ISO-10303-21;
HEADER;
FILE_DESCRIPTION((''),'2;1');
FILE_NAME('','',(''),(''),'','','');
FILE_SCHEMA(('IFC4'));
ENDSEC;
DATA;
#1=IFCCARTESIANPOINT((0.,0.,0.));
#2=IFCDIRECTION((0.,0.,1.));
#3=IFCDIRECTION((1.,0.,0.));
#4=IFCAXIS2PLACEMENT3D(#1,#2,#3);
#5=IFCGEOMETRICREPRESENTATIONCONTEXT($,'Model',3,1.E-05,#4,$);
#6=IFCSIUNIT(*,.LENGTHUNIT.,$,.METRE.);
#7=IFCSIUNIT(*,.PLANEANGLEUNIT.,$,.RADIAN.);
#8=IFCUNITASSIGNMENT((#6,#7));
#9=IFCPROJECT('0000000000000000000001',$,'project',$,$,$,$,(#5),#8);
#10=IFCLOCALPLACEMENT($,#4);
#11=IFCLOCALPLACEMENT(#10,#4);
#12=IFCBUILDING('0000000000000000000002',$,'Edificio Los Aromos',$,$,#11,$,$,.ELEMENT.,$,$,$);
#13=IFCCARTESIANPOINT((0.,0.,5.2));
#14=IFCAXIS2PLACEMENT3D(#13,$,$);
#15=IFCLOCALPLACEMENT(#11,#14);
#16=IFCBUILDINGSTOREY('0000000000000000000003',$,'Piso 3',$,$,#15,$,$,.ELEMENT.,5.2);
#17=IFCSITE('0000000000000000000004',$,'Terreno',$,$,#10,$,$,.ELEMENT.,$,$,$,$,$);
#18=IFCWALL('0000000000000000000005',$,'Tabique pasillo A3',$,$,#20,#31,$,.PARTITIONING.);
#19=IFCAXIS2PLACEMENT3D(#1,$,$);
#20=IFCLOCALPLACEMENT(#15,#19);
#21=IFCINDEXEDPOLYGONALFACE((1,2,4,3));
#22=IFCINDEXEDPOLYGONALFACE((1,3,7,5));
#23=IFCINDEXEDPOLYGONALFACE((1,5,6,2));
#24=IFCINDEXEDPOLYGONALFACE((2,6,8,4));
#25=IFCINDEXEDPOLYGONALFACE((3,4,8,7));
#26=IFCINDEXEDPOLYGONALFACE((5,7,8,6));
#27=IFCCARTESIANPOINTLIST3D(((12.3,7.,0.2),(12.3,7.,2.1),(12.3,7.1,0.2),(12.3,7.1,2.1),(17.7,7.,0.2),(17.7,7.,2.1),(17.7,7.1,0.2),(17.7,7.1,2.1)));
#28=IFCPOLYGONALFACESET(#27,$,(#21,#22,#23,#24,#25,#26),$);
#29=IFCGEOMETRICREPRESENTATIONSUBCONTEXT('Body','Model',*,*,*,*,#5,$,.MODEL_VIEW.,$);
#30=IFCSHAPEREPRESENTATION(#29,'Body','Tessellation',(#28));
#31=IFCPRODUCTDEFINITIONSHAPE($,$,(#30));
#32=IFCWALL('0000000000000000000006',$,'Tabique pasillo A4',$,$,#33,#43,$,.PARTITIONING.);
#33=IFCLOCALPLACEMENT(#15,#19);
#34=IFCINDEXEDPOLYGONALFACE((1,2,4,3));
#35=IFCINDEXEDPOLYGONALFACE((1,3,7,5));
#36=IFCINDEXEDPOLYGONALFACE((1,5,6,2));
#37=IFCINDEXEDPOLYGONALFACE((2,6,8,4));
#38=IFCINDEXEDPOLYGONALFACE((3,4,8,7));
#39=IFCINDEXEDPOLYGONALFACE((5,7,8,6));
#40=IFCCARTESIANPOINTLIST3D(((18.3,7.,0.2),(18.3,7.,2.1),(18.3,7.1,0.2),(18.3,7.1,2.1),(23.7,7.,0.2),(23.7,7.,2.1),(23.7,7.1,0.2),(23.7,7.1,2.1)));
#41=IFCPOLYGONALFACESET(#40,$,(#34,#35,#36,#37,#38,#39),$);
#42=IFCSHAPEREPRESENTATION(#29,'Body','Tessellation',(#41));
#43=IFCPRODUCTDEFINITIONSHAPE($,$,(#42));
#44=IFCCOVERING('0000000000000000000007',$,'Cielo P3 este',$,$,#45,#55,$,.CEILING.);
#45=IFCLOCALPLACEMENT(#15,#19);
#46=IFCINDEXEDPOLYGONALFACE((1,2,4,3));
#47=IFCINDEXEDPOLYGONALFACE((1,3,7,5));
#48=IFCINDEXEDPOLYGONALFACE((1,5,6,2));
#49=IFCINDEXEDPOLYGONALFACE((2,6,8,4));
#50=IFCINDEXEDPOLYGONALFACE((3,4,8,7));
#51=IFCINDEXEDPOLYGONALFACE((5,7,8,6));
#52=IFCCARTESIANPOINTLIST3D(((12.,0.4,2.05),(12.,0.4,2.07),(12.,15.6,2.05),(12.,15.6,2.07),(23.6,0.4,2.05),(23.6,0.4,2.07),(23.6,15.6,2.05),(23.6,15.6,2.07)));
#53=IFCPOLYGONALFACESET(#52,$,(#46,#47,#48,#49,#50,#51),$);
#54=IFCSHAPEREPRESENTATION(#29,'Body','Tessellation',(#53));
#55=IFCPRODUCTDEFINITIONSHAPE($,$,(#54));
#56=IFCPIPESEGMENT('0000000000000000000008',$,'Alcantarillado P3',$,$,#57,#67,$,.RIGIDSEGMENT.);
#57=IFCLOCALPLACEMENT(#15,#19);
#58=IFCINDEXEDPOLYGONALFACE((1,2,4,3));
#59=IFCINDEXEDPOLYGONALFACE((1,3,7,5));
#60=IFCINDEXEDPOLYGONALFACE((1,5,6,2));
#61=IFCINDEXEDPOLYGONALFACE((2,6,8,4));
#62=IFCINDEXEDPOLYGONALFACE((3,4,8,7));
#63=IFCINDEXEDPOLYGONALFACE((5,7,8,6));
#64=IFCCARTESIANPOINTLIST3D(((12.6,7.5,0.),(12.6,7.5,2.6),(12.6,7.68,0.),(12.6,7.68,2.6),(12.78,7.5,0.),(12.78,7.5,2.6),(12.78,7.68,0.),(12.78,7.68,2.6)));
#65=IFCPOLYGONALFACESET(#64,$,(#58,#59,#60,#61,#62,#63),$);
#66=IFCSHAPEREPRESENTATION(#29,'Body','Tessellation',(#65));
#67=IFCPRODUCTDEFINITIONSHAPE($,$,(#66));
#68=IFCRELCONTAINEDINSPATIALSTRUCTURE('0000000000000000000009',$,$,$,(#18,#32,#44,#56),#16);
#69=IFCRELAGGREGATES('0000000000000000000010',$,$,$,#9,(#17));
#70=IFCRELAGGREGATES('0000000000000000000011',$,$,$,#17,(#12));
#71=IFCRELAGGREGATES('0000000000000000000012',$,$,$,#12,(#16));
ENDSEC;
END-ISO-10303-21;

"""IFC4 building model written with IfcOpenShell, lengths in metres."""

from ifc_helpers import new_model, si_unit, frame, frame_2d, origin_with_axes, place, context, subcontext, project, spatial, rectangle, extrude, element, save


model = new_model("IFC4")

# Units and contexts
model_context = context("Model", 3, precision=1e-05, world=origin_with_axes())
body_context = subcontext(model_context, "Body", "Model", "MODEL_VIEW")
ifc_project = project(units=[si_unit("LENGTHUNIT", "METRE"), si_unit("PLANEANGLEUNIT", "RADIAN")], contexts=[model_context])

# Site, building, storey
site_placement = place(None, origin_with_axes())
site = spatial("IfcSite", under=ifc_project, at=site_placement, Name="Terreno", CompositionType="ELEMENT")
building_placement = place(site_placement, origin_with_axes())
building = spatial("IfcBuilding", under=site, at=building_placement, Name="Edificio Los Aromos", CompositionType="ELEMENT")
storey_placement = place(building_placement, frame((0.0, 0.0, 5.2)))
storey = spatial("IfcBuildingStorey", under=building, at=storey_placement, Name="Piso 3", CompositionType="ELEMENT", Elevation=5.2)

# Walls
for number, where, name in (
    (1, (12.3, 7.0, 0.2), "Tabique pasillo A3"),
    (2, (18.3, 7.0, 0.2), "Tabique pasillo A4"),
):
    element("IfcWall", number, at=place(storey_placement, frame(where)), inside=storey, Name=name, PredefinedType="PARTITIONING", context=body_context, shape_type="SweptSolid", body=[
        extrude(rectangle(XDim=5.4, YDim=0.1, at=frame_2d((2.7, 0.05))), origin_with_axes(), (0.0, 0.0, 1.0), 1.9),
    ])

# Covering
covering_placement = place(storey_placement, frame((12.0, 0.4, 2.05)))
element("IfcCovering", 3, at=covering_placement, inside=storey, Name="Cielo P3 este", PredefinedType="CEILING", context=body_context, shape_type="SweptSolid", body=[
    extrude(rectangle(XDim=11.6, YDim=15.2, at=frame_2d((5.8, 7.6))), origin_with_axes(), (0.0, 0.0, 1.0), 0.02),
])

# Pipe segment
pipe_segment_placement = place(storey_placement, frame((12.6, 7.5, 0.0)))
element("IfcPipeSegment", 4, at=pipe_segment_placement, inside=storey, Name="Alcantarillado P3", PredefinedType="RIGIDSEGMENT", context=body_context, shape_type="SweptSolid", body=[
    extrude(rectangle(XDim=0.18, YDim=0.18, at=frame_2d((0.09, 0.09))), origin_with_axes(), (0.0, 0.0, 1.0), 2.6),
])

save(model, "model.ifc")
